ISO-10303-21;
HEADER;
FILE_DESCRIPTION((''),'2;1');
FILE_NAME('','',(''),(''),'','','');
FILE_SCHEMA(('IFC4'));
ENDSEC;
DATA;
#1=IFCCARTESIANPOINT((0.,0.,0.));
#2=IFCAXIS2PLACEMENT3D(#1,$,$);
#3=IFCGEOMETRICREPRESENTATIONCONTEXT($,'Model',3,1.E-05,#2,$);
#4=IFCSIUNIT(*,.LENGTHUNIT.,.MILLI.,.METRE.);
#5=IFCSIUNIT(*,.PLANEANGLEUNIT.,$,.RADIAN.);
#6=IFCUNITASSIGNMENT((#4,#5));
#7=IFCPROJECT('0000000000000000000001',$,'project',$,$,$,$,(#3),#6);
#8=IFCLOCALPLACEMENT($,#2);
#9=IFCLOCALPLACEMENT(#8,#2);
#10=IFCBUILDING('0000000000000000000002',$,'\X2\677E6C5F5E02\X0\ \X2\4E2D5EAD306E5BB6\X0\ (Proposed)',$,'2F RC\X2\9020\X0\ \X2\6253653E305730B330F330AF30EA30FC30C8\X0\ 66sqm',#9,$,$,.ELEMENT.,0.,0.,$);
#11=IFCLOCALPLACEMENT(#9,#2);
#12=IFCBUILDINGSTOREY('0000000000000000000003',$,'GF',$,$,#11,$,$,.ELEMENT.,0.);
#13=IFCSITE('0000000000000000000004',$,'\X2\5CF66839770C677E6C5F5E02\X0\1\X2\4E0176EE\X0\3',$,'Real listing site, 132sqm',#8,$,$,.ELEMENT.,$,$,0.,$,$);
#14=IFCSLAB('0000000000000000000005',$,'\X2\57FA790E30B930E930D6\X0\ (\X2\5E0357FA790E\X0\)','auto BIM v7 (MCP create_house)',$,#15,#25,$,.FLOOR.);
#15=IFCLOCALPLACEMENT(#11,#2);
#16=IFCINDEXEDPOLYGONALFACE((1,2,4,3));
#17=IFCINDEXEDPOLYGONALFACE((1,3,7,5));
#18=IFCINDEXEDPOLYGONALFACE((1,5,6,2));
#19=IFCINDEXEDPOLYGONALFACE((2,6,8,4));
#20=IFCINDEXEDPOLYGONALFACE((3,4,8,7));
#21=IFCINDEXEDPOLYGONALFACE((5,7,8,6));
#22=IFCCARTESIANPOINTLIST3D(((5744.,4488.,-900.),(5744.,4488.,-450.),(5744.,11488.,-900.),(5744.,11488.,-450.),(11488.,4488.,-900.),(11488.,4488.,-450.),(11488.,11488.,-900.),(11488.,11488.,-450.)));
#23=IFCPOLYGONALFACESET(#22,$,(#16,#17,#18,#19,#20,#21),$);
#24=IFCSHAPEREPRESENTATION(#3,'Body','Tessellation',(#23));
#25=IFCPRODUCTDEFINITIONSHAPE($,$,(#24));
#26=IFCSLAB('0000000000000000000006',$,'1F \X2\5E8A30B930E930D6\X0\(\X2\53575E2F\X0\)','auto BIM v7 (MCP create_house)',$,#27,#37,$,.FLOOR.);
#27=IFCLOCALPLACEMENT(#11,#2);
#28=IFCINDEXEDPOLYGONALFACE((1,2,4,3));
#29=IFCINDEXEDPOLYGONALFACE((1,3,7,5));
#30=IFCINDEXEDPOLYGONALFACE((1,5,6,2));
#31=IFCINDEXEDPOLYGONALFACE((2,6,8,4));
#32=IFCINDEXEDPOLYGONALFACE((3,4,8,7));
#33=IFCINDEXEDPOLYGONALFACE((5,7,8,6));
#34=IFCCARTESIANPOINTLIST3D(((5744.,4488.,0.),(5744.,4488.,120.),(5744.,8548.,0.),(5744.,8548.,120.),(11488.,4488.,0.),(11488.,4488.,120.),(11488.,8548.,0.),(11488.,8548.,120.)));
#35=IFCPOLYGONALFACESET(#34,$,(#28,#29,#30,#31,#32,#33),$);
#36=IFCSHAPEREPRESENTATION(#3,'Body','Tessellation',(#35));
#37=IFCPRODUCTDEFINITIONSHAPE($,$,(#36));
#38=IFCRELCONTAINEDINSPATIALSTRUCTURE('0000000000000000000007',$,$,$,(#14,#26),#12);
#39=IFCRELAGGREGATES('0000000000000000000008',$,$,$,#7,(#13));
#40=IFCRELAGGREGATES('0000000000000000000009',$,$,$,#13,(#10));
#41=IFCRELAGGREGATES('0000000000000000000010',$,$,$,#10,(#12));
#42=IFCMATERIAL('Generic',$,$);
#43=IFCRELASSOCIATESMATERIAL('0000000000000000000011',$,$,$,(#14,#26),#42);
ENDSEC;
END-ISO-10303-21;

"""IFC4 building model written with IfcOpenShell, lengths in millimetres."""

from ifc_helpers import new_model, si_unit, frame, frame_2d, origin, place, context, project, spatial, rectangle, extrude, material, element, save


model = new_model("IFC4")

# Units and contexts
model_context = context("Model", 3, precision=1e-05, world=origin())
ifc_project = project(units=[si_unit("LENGTHUNIT", "METRE", prefix="MILLI"), si_unit("PLANEANGLEUNIT", "RADIAN")], contexts=[model_context])

# Site, building, storey
site_placement = place(None, origin())
site = spatial("IfcSite", under=ifc_project, at=site_placement, Name="島根県松江市1丁目3", ObjectType="Real listing site, 132sqm", CompositionType="ELEMENT", RefElevation=0.0)
building_placement = place(site_placement, origin())
building = spatial("IfcBuilding", under=site, at=building_placement, Name="松江市 中庭の家 (Proposed)", ObjectType="2F RC造 打放しコンクリート 66sqm", CompositionType="ELEMENT", ElevationOfRefHeight=0.0, ElevationOfTerrain=0.0)
storey_placement = place(building_placement, origin())
storey = spatial("IfcBuildingStorey", under=building, at=storey_placement, Name="GF", CompositionType="ELEMENT", Elevation=0.0)

# Slabs
ifc_material = material(Name="Generic")
slab_1_placement = place(storey_placement, frame((2872.0, 2244.0, -450.0)))
element("IfcSlab", 1, at=slab_1_placement, inside=storey, material=ifc_material, Name="基礎スラブ (布基礎)", Description="auto BIM v7 (MCP create_house)", PredefinedType="FLOOR", context=model_context, shape_type="SweptSolid", body=[
    extrude(rectangle(XDim=5744.0, YDim=7000.0, at=frame_2d((2872.0, 3500.0))), frame((2872.0, 2244.0, -450.0)), (0.0, 0.0, 1.0), 450.0),
])
slab_2_placement = place(storey_placement, frame((2872.0, 2244.0, 0.0)))
element("IfcSlab", 2, at=slab_2_placement, inside=storey, material=ifc_material, Name="1F 床スラブ(南帯)", Description="auto BIM v7 (MCP create_house)", PredefinedType="FLOOR", context=model_context, shape_type="SweptSolid", body=[
    extrude(rectangle(XDim=5744.0, YDim=4060.0, at=frame_2d((2872.0, 2030.0))), frame((2872.0, 2244.0, 0.0)), (0.0, 0.0, 1.0), 120.0),
])

save(model, "model.ifc")
